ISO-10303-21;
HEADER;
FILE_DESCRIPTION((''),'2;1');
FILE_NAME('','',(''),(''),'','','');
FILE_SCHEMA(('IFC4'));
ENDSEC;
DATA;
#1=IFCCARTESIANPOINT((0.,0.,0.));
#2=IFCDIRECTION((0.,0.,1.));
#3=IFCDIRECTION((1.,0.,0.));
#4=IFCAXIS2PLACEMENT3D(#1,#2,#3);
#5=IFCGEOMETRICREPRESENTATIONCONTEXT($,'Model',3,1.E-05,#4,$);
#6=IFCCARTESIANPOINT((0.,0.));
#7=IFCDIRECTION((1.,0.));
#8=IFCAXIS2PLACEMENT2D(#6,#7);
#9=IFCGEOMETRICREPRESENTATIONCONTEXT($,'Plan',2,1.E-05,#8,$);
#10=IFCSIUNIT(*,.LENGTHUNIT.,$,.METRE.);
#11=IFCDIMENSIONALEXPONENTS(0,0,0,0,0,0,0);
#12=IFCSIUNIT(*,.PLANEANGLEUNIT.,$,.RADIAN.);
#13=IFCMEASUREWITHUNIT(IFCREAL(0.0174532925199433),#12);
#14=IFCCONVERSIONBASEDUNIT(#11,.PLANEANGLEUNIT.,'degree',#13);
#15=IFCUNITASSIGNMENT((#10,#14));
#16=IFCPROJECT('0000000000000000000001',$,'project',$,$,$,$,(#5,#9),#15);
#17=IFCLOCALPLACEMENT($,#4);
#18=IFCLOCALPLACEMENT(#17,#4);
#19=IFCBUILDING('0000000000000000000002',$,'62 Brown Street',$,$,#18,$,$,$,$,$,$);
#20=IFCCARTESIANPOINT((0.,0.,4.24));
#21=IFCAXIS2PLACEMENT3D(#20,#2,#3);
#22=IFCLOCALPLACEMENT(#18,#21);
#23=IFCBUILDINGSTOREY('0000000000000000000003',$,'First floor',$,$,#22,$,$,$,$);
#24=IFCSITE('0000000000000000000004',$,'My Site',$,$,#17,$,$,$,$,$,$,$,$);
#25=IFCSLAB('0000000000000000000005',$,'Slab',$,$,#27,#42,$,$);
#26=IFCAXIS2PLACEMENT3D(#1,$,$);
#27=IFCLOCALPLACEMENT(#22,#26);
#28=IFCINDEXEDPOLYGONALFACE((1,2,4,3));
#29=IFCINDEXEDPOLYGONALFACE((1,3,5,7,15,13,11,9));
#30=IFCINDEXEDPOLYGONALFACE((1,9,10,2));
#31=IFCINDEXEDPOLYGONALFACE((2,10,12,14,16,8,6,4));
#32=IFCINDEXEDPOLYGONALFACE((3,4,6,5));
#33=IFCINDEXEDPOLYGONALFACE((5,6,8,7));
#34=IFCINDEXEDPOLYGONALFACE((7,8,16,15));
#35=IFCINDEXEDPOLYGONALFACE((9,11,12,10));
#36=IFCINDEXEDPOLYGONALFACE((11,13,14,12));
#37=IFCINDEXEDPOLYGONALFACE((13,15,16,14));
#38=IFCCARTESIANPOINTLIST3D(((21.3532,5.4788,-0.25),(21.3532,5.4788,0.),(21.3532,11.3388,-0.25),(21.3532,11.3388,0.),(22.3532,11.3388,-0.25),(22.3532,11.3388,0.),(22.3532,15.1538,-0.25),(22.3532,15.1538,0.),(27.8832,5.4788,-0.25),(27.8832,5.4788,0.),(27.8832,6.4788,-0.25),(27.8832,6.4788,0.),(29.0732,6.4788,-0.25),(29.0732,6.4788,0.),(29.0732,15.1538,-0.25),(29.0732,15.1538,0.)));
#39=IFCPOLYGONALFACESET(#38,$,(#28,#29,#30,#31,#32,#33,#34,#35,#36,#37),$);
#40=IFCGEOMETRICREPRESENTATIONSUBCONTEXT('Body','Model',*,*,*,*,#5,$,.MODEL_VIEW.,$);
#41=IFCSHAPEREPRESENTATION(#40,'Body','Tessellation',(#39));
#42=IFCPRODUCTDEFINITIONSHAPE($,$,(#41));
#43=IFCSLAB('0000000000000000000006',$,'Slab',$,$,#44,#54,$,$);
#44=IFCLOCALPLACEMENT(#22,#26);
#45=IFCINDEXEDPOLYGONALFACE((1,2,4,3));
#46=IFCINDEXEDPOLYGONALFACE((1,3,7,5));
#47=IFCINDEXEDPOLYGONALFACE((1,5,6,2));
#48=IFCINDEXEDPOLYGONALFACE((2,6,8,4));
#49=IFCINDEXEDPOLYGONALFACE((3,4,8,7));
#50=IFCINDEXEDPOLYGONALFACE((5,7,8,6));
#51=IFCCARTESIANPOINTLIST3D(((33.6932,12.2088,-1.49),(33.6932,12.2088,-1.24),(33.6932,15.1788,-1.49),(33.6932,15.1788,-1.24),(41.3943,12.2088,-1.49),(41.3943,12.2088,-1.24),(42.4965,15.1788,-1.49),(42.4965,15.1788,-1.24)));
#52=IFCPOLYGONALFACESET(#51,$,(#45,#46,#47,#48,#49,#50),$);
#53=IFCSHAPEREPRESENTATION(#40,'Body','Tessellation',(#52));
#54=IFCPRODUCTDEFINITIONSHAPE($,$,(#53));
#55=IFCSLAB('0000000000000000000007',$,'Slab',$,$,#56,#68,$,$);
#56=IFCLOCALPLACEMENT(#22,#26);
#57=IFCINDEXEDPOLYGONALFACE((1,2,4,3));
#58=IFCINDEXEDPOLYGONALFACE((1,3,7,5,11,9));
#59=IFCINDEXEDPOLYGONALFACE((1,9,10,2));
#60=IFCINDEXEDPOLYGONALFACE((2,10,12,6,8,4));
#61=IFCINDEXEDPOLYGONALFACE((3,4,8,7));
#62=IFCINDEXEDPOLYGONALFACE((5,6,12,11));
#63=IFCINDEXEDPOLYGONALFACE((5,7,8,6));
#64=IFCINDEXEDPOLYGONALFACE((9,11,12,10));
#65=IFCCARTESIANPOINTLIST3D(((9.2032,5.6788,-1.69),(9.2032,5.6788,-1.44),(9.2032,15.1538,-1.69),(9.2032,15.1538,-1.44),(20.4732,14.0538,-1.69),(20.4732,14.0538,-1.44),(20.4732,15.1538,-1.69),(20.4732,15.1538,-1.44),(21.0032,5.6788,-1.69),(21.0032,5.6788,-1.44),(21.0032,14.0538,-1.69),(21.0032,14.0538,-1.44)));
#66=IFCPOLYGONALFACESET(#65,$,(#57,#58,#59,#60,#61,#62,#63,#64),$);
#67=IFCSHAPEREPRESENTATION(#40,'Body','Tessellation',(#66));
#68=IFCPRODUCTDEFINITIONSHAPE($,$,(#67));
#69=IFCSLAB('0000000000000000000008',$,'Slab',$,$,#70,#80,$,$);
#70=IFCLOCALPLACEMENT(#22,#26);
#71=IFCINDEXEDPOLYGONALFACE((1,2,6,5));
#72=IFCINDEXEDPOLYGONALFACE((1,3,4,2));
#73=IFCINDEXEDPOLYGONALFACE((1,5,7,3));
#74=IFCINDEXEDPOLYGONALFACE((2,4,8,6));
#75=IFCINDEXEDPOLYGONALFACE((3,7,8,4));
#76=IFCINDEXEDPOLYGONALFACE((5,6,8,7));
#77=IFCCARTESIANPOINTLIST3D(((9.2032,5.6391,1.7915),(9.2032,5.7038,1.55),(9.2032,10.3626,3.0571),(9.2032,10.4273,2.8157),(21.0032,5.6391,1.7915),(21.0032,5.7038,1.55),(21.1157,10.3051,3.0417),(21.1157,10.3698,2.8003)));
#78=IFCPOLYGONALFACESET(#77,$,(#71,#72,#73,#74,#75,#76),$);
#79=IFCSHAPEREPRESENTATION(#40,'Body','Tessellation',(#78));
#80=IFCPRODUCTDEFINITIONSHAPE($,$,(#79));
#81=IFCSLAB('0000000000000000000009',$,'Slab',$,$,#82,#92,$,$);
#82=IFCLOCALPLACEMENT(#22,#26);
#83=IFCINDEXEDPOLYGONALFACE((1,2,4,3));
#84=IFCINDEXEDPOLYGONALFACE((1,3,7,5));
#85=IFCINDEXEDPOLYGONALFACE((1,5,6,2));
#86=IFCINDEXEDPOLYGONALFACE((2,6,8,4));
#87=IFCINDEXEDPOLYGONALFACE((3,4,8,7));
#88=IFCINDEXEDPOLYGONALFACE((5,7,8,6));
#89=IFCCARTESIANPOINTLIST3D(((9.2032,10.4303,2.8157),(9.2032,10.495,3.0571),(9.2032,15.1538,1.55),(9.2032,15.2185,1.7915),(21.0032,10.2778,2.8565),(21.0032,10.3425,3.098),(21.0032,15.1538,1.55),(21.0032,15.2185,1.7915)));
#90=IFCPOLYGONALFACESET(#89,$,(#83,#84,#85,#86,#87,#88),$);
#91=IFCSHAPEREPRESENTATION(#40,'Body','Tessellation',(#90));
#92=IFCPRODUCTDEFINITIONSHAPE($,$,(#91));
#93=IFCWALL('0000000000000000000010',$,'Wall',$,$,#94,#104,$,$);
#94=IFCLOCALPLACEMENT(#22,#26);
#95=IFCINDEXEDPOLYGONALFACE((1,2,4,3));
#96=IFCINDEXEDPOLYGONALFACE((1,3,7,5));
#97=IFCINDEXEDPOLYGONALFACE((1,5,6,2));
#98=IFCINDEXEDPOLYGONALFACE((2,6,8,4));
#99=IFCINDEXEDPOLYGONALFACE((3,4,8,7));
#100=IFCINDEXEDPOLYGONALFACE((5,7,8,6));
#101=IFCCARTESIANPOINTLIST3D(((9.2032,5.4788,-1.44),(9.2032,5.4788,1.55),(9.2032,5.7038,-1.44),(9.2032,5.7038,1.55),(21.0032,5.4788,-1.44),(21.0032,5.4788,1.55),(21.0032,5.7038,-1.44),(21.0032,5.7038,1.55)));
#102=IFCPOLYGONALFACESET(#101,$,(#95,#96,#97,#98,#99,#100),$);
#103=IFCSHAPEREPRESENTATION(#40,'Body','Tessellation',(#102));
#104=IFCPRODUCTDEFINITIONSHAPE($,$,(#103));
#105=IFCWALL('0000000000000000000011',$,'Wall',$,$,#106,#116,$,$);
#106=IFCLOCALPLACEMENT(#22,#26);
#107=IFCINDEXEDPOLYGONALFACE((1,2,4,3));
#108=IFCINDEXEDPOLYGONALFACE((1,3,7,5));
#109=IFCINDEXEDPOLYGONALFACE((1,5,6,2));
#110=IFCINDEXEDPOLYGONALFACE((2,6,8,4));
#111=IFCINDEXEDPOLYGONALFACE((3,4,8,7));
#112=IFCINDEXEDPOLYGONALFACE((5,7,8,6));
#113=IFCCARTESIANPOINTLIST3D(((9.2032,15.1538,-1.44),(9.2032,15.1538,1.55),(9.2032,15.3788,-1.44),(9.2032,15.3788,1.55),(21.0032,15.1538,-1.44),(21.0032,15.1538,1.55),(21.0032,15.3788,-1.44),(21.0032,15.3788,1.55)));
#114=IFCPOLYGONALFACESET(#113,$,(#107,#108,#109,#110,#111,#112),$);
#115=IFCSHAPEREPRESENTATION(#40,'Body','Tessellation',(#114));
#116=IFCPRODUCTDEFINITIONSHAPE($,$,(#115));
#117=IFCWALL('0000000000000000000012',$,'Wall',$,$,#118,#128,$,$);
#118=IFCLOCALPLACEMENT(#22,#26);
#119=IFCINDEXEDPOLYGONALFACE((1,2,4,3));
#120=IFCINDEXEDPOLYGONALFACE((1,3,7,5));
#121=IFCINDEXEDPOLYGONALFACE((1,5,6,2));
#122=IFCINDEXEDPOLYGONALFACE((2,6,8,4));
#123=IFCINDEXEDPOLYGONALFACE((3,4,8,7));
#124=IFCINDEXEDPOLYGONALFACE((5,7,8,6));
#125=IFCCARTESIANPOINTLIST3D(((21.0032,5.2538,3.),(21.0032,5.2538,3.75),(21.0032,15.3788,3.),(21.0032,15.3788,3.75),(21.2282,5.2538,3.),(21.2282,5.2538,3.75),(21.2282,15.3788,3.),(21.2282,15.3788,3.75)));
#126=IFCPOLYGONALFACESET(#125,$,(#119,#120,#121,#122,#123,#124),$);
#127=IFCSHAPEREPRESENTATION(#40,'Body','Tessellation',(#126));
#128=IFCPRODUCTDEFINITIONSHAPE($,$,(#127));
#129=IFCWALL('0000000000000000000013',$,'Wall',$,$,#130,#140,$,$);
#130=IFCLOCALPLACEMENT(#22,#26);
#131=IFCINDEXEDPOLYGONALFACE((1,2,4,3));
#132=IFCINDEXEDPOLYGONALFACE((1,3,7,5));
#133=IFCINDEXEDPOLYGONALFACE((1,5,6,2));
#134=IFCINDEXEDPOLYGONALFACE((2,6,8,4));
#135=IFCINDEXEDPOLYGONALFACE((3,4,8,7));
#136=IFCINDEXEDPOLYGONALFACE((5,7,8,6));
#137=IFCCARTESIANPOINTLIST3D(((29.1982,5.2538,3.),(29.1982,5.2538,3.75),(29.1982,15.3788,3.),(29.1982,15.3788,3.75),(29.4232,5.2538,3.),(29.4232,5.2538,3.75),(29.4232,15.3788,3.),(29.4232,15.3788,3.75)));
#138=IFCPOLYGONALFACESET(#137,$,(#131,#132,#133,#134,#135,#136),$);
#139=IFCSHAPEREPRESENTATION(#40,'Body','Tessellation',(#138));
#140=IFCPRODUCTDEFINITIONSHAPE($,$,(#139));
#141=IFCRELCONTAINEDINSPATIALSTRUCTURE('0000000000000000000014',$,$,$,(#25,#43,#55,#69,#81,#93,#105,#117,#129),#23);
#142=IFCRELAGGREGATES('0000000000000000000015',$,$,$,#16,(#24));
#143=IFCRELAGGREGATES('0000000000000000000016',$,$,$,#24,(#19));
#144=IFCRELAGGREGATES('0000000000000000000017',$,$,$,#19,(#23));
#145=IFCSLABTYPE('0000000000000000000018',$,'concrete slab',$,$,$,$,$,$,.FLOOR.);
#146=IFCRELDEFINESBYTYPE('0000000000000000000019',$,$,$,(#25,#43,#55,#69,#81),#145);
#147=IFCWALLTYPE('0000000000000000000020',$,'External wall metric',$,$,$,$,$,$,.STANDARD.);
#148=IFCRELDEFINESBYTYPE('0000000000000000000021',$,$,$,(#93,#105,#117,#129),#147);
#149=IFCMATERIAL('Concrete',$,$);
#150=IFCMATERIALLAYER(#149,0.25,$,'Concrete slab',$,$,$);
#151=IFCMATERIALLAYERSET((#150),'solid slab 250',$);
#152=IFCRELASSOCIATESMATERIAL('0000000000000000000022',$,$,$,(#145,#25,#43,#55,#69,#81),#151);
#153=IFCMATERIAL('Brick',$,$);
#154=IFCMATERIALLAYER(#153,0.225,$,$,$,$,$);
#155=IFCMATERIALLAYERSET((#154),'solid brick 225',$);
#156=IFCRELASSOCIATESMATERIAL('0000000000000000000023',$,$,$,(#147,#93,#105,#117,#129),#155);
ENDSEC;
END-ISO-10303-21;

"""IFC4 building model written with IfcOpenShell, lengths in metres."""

from ifc_helpers import new_model, entity, si_unit, converted_unit, frame, origin_with_axes, origin_2d_with_axis, place, context, subcontext, project, spatial, line, indexed_curve, outline, extrude, material, layer, layer_set, layer_usage, type_object, element, save


model = new_model("IFC4")

# Units and contexts
model_context = context("Model", 3, precision=1e-05, world=origin_with_axes())
plan_context = context("Plan", 2, precision=1e-05, world=origin_2d_with_axis())
body_context_1 = subcontext(model_context, "Body", "Model", "MODEL_VIEW")
ifc_project = project(units=[si_unit("LENGTHUNIT", "METRE"), converted_unit("PLANEANGLEUNIT", "degree", entity("IfcReal", 0.0174532925199433), si_unit("PLANEANGLEUNIT", "RADIAN"), dimensions=[0, 0, 0, 0, 0, 0, 0])], contexts=[model_context, plan_context])

# Site, building, storey
site_placement = place(None, origin_with_axes())
site = spatial("IfcSite", under=ifc_project, at=site_placement, Name="My Site")
building_placement = place(site_placement, origin_with_axes())
building = spatial("IfcBuilding", under=site, at=building_placement, Name="62 Brown Street")
storey_placement = place(building_placement, frame((0.0, 0.0, 4.24), z_axis=(0.0, 0.0, 1.0), x_axis=(1.0, 0.0, 0.0)))
storey = spatial("IfcBuildingStorey", under=building, at=storey_placement, Name="First floor")

# Slabs
ifc_material_1 = material(Name="Concrete")
ifc_layer_1 = layer(ifc_material_1, 0.25, Name="Concrete slab")
ifc_layer_set_1 = layer_set([ifc_layer_1], Name="solid slab 250")
ifc_layer_usage_1 = layer_usage(ifc_layer_set_1, "AXIS3", "POSITIVE", 0.0)
slab_type = type_object("IfcSlabType", Name="concrete slab", PredefinedType="FLOOR", material=ifc_layer_set_1)
slab_1_placement = place(storey_placement, frame((21.3532, 5.4788, -0.25), z_axis=(0.0, 0.0, 1.0), x_axis=(1.0, 0.0, 0.0)))
element("IfcSlab", 1, at=slab_1_placement, inside=storey, type_object=slab_type, material=ifc_layer_usage_1, Name="Slab", context=body_context_1, shape_type="SweptSolid", body=[
    extrude(outline(indexed_curve([(0.0, 0.0), (0.0, 5.86), (1.0, 5.86), (1.0, 9.675), (7.72, 9.675), (7.72, 1.0), (6.53, 1.0), (6.53, 0.0)], segments=[line(2, 1), line(1, 8), line(8, 7), line(7, 6), line(6, 5), line(5, 4), line(4, 3), line(3, 2)], self_intersect=False)), None, (0.0, 0.0, 1.0), 0.25),
])
ifc_layer_usage_2 = layer_usage(ifc_layer_set_1, "AXIS3", "POSITIVE", 0.0)
slab_2_placement = place(storey_placement, frame((33.6932, 12.2088, -1.49), z_axis=(0.0, 0.0, 1.0), x_axis=(1.0, 0.0, 0.0)))
element("IfcSlab", 2, at=slab_2_placement, inside=storey, type_object=slab_type, material=ifc_layer_usage_2, Name="Slab", context=body_context_1, shape_type="SweptSolid", body=[
    extrude(outline(indexed_curve([(8.8033, 2.97), (7.7011, 0.0), (0.0, 0.0), (0.0, 2.97)], segments=[line(4, 1), line(1, 2), line(2, 3), line(3, 4)], self_intersect=False)), None, (0.0, 0.0, 1.0), 0.25),
])
ifc_layer_usage_3 = layer_usage(ifc_layer_set_1, "AXIS3", "POSITIVE", 0.0)
slab_3_placement = place(storey_placement, frame((9.2032, 5.6788, -1.69), z_axis=(0.0, 0.0, 1.0), x_axis=(1.0, 0.0, 0.0)))
element("IfcSlab", 3, at=slab_3_placement, inside=storey, type_object=slab_type, material=ifc_layer_usage_3, Name="Slab", context=body_context_1, shape_type="SweptSolid", body=[
    extrude(outline(indexed_curve([(11.27, 9.475), (11.8, 0.0), (0.0, 0.0), (0.0, 9.475), (11.8, 8.375), (11.27, 8.375)], segments=[line(6, 1), line(1, 4), line(4, 3), line(3, 2), line(2, 5), line(5, 6)], self_intersect=False)), None, (0.0, 0.0, 1.0), 0.25),
])
ifc_layer_usage_4 = layer_usage(ifc_layer_set_1, "AXIS3", "POSITIVE", 0.0)
slab_4_placement = place(storey_placement, frame((9.2032, 5.7038, 1.55), z_axis=(0.0, -0.258819, 0.965926), x_axis=(1.0, 0.0, 0.0)))
element("IfcSlab", 4, at=slab_4_placement, inside=storey, type_object=slab_type, material=ifc_layer_usage_4, Name="Slab", context=body_context_1, shape_type="SweptSolid", body=[
    extrude(outline(indexed_curve([(0.0, 0.0), (11.8, 0.0), (11.9125, 4.8306), (0.0, 4.8901)], segments=[line(4, 1), line(1, 2), line(2, 3), line(3, 4)], self_intersect=False)), None, (0.0, 0.0, 1.0), 0.25),
])
ifc_layer_usage_5 = layer_usage(ifc_layer_set_1, "AXIS3", "POSITIVE", 0.0)
slab_5_placement = place(storey_placement, frame((21.0032, 15.1538, 1.55), z_axis=(0.0, 0.258819, 0.965926), x_axis=(-1.0, 0.0, 0.0)))
element("IfcSlab", 5, at=slab_5_placement, inside=storey, type_object=slab_type, material=ifc_layer_usage_5, Name="Slab", context=body_context_1, shape_type="SweptSolid", body=[
    extrude(outline(indexed_curve([(0.0, 0.0), (11.8, 0.0), (11.8, 4.8901), (0.0, 5.048)], segments=[line(4, 1), line(1, 2), line(2, 3), line(3, 4)], self_intersect=False)), None, (0.0, 0.0, 1.0), 0.25),
])

# Walls
ifc_material_2 = material(Name="Brick")
ifc_layer_2 = layer(ifc_material_2, 0.225)
ifc_layer_set_2 = layer_set([ifc_layer_2], Name="solid brick 225")
ifc_layer_usage_6 = layer_usage(ifc_layer_set_2, "AXIS2", "POSITIVE", 0.0)
wall_type_1 = type_object("IfcWallType", Name="External wall metric", PredefinedType="STANDARD", material=ifc_layer_set_2)
wall_1_placement = place(storey_placement, frame((9.2032, 5.4788, -1.44), z_axis=(0.0, 0.0, 1.0), x_axis=(1.0, 0.0, 0.0)))
element("IfcWall", 6, at=wall_1_placement, inside=storey, type_object=wall_type_1, material=ifc_layer_usage_6, Name="Wall", context=body_context_1, shape_type="SweptSolid", body=[
    extrude(outline(indexed_curve([(0.0, 0.0), (0.0, 0.225), (11.8, 0.225), (11.8, 0.0), (0.0, 0.0)], self_intersect=False)), origin_with_axes(), (0.0, 0.0, 1.0), 2.99),
])
ifc_layer_usage_7 = layer_usage(ifc_layer_set_2, "AXIS2", "POSITIVE", 0.0)
wall_2_placement = place(storey_placement, frame((21.0032, 15.3788, -1.44), z_axis=(0.0, 0.0, 1.0), x_axis=(-1.0, 0.0, 0.0)))
element("IfcWall", 7, at=wall_2_placement, inside=storey, type_object=wall_type_1, material=ifc_layer_usage_7, Name="Wall", context=body_context_1, shape_type="SweptSolid", body=[
    extrude(outline(indexed_curve([(0.0, 0.0), (0.0, 0.225), (11.8, 0.225), (11.8, 0.0), (0.0, 0.0)], self_intersect=False)), origin_with_axes(), (0.0, 0.0, 1.0), 2.99),
])

# Walls
ifc_layer_usage_8 = layer_usage(ifc_layer_set_2, "AXIS2", "POSITIVE", 0.0)
wall_3_placement = place(storey_placement, frame((21.0032, 15.3788, 3.0), z_axis=(0.0, 0.0, 1.0), x_axis=(0.0, -1.0, 0.0)))
element("IfcWall", 8, at=wall_3_placement, inside=storey, type_object=wall_type_1, material=ifc_layer_usage_8, Name="Wall", context=body_context_1, shape_type="SweptSolid", body=[
    extrude(outline(indexed_curve([(0.0, 0.0), (0.0, 0.225), (10.125, 0.225), (10.125, 0.0), (0.0, 0.0)], self_intersect=False)), origin_with_axes(), (0.0, 0.0, 1.0), 0.75),
])
ifc_layer_usage_9 = layer_usage(ifc_layer_set_2, "AXIS2", "POSITIVE", 0.0)
wall_4_placement = place(storey_placement, frame((29.4232, 5.2538, 3.0), z_axis=(0.0, 0.0, 1.0), x_axis=(0.0, 1.0, 0.0)))
element("IfcWall", 9, at=wall_4_placement, inside=storey, type_object=wall_type_1, material=ifc_layer_usage_9, Name="Wall", context=body_context_1, shape_type="SweptSolid", body=[
    extrude(outline(indexed_curve([(0.0, 0.0), (0.0, 0.225), (10.125, 0.225), (10.125, 0.0), (0.0, 0.0)], self_intersect=False)), origin_with_axes(), (0.0, 0.0, 1.0), 0.75),
])

save(model, "model.ifc")
